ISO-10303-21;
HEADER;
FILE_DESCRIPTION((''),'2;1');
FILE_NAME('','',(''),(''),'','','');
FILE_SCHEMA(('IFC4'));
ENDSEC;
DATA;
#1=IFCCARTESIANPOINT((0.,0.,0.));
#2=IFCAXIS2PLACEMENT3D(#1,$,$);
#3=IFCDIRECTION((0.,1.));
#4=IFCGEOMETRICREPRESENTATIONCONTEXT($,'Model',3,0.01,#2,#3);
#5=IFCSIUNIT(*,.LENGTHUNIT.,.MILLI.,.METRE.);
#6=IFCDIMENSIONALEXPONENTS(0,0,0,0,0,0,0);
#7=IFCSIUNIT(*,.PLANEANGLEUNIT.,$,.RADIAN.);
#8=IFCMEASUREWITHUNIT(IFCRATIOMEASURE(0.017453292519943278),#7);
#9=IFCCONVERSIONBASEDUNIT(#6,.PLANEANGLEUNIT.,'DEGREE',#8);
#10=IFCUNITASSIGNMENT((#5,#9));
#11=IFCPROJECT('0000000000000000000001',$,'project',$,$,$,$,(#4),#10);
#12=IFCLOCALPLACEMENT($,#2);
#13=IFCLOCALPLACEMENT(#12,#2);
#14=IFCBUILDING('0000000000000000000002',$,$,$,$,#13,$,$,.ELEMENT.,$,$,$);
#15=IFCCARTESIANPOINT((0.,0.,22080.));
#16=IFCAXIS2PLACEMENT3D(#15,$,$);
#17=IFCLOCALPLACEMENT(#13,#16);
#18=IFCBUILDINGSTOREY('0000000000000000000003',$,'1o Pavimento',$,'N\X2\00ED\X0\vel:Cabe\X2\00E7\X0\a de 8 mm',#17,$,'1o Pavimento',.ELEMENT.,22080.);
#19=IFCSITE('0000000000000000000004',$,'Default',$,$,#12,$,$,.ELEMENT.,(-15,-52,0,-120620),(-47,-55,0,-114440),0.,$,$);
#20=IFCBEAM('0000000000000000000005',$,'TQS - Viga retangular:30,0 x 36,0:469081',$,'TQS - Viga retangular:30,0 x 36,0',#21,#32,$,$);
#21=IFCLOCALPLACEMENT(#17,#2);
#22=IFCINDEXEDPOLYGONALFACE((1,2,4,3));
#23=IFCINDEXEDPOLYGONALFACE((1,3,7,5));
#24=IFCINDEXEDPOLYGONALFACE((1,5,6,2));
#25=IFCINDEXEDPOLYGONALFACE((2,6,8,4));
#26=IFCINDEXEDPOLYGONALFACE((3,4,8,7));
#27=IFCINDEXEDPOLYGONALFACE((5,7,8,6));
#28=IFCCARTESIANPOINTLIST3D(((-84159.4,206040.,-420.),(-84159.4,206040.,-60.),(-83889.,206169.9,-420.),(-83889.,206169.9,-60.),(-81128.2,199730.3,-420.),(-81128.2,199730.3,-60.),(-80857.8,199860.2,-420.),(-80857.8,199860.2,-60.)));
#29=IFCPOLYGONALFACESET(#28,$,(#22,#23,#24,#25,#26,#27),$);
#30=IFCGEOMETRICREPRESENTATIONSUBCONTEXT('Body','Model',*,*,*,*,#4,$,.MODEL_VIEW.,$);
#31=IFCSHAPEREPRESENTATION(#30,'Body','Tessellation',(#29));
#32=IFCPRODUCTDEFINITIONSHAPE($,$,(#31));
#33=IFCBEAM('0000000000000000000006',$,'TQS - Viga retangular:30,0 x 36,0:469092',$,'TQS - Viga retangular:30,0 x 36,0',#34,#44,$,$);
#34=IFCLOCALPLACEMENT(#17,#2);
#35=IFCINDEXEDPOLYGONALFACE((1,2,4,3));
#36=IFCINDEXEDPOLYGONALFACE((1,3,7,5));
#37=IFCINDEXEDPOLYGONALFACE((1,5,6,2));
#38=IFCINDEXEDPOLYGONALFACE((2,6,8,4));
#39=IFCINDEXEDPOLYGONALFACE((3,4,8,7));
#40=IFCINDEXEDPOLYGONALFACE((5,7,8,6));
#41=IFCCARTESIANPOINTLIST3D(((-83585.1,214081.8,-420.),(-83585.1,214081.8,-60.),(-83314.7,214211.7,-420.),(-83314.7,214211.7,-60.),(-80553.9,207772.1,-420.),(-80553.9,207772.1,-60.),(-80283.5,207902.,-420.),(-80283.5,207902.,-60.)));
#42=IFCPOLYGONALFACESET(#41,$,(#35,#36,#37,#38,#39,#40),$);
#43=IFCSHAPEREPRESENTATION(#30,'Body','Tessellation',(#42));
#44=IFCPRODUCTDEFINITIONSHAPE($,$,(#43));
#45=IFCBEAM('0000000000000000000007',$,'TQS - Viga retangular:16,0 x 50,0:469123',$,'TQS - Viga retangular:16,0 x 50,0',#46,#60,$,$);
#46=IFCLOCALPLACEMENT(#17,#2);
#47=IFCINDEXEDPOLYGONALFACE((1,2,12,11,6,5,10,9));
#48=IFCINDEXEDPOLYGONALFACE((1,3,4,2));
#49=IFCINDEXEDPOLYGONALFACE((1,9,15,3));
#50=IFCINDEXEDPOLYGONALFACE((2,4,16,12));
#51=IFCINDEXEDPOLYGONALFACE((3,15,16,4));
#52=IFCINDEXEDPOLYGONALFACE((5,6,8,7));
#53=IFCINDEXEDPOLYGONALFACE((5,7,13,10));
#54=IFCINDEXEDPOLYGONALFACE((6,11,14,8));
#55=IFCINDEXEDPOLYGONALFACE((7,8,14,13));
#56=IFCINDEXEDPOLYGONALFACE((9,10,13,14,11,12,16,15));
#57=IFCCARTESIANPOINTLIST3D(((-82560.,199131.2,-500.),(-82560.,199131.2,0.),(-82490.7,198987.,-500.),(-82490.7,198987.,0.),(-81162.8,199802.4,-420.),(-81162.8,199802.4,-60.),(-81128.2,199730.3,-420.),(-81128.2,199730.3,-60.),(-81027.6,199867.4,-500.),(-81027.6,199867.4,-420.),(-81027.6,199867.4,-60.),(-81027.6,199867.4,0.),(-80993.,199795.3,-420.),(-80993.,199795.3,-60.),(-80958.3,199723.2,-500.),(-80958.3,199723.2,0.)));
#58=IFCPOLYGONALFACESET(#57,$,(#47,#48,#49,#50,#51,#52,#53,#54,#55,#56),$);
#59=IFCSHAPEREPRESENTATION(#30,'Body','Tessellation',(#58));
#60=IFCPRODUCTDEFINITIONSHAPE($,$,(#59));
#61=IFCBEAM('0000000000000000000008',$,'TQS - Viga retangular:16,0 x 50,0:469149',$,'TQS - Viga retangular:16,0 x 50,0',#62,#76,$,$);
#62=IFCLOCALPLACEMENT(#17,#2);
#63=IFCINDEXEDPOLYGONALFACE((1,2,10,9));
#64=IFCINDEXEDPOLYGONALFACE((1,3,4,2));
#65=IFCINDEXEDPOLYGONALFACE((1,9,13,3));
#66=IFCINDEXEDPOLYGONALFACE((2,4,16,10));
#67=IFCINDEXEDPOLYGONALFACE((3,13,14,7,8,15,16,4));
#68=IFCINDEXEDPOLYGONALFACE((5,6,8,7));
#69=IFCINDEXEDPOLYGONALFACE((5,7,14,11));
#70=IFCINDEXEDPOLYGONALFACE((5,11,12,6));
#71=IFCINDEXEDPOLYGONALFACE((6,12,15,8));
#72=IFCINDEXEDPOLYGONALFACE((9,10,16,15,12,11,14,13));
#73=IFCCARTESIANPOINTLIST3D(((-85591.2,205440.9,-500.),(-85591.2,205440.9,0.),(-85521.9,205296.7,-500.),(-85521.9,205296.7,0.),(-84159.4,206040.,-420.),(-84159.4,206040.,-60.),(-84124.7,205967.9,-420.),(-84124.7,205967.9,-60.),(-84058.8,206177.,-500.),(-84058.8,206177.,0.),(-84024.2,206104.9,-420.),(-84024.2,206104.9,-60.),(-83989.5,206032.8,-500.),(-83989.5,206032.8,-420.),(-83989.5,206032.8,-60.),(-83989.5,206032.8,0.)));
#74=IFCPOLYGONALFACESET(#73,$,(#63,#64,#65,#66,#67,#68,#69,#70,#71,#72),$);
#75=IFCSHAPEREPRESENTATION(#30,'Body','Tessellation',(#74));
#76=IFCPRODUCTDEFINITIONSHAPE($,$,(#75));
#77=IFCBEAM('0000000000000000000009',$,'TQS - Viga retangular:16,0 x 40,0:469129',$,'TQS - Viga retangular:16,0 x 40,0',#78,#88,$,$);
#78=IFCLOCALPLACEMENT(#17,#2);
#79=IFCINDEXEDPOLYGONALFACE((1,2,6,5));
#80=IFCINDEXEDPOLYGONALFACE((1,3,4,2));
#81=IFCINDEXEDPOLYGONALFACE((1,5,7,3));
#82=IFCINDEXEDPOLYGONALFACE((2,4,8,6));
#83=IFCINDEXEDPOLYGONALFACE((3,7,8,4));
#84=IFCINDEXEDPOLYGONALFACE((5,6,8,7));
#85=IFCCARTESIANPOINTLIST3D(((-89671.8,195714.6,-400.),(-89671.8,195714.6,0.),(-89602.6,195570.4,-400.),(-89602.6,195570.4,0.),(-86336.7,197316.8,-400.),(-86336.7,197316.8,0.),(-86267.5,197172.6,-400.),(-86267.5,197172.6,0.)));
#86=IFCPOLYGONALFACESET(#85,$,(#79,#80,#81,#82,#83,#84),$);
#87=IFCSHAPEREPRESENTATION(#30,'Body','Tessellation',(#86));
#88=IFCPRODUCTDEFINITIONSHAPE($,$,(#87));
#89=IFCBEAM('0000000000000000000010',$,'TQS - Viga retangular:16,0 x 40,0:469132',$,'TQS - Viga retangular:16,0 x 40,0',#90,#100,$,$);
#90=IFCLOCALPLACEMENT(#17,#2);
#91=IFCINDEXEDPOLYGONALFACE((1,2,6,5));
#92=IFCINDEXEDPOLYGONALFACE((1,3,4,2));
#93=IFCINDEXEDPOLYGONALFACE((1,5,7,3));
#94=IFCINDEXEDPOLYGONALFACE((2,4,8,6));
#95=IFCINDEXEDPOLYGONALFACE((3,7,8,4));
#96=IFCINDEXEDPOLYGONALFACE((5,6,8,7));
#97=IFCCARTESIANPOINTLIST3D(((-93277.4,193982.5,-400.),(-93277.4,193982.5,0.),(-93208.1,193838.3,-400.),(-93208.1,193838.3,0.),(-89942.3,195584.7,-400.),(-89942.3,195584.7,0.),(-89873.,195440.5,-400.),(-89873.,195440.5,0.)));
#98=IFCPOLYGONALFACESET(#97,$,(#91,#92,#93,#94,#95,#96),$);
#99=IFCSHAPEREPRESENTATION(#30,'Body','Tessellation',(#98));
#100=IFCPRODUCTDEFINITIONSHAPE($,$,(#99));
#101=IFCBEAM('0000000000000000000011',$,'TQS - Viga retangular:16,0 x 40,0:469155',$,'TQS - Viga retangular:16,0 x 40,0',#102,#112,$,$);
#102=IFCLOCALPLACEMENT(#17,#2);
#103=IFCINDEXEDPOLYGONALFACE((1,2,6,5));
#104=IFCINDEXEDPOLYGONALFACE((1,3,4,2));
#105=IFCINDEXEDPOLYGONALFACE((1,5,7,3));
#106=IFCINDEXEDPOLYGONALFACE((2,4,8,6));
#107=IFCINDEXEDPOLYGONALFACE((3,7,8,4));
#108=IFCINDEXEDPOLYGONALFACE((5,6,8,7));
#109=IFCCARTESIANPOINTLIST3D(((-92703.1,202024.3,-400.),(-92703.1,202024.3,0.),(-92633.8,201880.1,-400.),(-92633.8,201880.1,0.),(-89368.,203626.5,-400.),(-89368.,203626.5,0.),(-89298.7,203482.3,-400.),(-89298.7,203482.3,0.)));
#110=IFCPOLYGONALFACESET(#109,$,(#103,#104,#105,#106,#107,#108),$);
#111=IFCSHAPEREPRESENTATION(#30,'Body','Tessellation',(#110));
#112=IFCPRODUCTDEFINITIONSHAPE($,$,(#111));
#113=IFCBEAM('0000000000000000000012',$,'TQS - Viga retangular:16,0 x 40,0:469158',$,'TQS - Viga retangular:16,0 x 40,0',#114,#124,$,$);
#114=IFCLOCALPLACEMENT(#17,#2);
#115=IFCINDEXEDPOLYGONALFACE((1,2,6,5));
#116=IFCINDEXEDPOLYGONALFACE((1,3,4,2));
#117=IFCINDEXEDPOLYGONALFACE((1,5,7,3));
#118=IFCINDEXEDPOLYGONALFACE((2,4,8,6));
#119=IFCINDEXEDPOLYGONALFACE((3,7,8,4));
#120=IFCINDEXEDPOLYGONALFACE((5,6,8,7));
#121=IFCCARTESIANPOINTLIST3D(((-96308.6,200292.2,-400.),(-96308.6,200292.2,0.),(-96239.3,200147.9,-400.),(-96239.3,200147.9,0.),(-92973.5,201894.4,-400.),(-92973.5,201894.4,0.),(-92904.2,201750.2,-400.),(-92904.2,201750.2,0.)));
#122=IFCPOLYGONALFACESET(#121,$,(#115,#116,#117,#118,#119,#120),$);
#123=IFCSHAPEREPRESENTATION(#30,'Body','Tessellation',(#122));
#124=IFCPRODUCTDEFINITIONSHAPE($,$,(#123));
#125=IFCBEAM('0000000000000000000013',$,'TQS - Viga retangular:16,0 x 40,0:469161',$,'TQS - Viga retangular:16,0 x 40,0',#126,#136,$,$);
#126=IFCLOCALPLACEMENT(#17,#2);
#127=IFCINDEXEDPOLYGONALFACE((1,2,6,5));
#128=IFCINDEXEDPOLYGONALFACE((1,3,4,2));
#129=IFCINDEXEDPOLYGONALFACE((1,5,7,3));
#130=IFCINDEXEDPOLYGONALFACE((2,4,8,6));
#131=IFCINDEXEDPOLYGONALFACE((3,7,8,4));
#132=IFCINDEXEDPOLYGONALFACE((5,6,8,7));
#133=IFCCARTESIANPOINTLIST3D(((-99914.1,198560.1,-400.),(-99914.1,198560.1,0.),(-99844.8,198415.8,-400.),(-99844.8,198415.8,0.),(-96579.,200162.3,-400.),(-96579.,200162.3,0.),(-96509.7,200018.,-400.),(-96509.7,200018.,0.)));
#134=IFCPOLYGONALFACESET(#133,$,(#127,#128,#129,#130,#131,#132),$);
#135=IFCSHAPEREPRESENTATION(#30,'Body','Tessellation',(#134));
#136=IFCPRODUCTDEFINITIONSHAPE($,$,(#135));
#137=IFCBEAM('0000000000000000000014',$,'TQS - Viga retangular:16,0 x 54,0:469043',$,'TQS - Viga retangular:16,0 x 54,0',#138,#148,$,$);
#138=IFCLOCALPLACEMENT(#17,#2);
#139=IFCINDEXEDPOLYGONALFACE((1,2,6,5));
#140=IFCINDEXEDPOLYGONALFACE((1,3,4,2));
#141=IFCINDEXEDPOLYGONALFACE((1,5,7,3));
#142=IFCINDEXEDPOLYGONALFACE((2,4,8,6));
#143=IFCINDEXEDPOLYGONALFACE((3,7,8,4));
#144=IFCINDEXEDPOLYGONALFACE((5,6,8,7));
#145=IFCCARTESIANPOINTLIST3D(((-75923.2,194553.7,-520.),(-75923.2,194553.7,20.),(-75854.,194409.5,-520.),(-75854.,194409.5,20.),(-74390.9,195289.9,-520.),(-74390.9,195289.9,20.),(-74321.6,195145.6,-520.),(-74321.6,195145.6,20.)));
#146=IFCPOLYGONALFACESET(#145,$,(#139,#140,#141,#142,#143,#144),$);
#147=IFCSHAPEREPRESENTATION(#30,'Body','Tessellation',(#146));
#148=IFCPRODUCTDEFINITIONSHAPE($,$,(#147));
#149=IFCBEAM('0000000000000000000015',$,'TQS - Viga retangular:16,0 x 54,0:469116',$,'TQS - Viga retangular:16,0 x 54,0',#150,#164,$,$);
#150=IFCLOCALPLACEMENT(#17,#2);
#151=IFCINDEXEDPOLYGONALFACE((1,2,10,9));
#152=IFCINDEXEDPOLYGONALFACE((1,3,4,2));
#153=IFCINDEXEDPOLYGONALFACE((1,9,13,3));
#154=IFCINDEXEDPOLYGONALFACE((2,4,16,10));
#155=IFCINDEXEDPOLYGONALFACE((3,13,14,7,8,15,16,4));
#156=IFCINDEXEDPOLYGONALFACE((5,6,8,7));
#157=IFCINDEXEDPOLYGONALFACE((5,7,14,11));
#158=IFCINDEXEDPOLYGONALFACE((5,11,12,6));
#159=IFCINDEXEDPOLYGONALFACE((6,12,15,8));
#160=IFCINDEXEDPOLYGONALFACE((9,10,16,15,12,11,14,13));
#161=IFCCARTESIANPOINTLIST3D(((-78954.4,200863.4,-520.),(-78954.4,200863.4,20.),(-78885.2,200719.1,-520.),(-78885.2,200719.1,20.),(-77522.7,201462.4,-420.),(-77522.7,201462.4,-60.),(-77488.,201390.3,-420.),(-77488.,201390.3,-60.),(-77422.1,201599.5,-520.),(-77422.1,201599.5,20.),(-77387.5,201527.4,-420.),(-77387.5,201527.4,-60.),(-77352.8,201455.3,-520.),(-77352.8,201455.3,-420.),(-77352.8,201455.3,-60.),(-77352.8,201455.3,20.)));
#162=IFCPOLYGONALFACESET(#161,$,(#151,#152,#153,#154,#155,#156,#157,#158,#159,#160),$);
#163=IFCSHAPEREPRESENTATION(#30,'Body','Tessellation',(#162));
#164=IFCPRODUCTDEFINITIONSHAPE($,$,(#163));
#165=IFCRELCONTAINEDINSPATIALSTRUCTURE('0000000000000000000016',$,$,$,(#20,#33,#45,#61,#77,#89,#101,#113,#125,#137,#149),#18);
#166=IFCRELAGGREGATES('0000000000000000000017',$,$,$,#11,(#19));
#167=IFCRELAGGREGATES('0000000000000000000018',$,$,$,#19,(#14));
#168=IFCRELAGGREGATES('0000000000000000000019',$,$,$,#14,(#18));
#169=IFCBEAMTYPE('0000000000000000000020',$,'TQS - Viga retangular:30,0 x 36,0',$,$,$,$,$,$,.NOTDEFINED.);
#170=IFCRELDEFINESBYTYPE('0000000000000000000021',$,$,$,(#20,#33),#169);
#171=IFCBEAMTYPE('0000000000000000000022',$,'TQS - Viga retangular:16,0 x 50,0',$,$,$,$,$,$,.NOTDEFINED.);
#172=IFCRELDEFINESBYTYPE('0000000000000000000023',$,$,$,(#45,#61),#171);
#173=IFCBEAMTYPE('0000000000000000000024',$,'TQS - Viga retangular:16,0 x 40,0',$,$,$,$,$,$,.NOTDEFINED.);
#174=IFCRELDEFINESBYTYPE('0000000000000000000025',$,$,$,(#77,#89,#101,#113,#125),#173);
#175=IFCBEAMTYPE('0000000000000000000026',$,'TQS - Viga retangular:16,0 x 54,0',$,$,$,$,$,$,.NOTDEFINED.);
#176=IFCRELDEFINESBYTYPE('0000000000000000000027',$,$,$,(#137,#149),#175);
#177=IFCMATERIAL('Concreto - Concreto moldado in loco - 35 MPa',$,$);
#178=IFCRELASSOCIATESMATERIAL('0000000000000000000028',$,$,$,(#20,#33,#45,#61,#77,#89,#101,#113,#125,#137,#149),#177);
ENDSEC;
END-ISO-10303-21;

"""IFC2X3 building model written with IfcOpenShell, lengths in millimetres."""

from ifc_helpers import new_model, entity, si_unit, converted_unit, direction, frame, frame_2d, origin, origin_2d_with_axis, place, context, subcontext, project, spatial, polyline, rectangle, extrude, boolean, clip, bounded_halfspace, material, type_object, element, save


model = new_model("IFC2X3")

# Units and contexts
model_context = context("Model", 3, precision=0.01, world=origin(), true_north=direction((0.0, 1.0)))
body_context = subcontext(model_context, "Body", "Model", "MODEL_VIEW")
ifc_project = project(units=[si_unit("LENGTHUNIT", "METRE", prefix="MILLI"), converted_unit("PLANEANGLEUNIT", "DEGREE", entity("IfcRatioMeasure", 0.017453292519943278), si_unit("PLANEANGLEUNIT", "RADIAN"), dimensions=[0, 0, 0, 0, 0, 0, 0])], contexts=[model_context])

# Site, building, storey
site_placement = place(None, origin())
site = spatial("IfcSite", under=ifc_project, at=site_placement, Name="Default", CompositionType="ELEMENT", RefLatitude=(-15, -52, 0, -120620), RefLongitude=(-47, -55, 0, -114440), RefElevation=0.0)
building_placement = place(site_placement, origin())
building = spatial("IfcBuilding", under=site, at=building_placement, CompositionType="ELEMENT")
storey_placement = place(building_placement, frame((0.0, 0.0, 22080.0)))
storey = spatial("IfcBuildingStorey", under=building, at=storey_placement, Name="1o Pavimento", ObjectType="Nível:Cabeça de 8 mm", LongName="1o Pavimento", CompositionType="ELEMENT", Elevation=22080.0)

# Beams
ifc_material_1 = material(Name="Concreto - Concreto moldado in loco - 35 MPa")
beam_type_1 = type_object("IfcBeamType", Name="TQS - Viga retangular:30,0 x 36,0", PredefinedType="NOTDEFINED")
beam_1_placement = place(storey_placement, frame((-80993.0, 199795.3, -60.0), z_axis=(0.0, 0.0, 1.0), x_axis=(-0.43303, 0.90138, 0.0)))
element("IfcBeam", 1, at=beam_1_placement, inside=storey, type_object=beam_type_1, material=ifc_material_1, Name="TQS - Viga retangular:30,0 x 36,0:469081", ObjectType="TQS - Viga retangular:30,0 x 36,0", context=body_context, shape_type="SweptSolid", body=[
    extrude(rectangle(XDim=360.0, YDim=300.0, at=frame_2d((0.0, 0.0), x_axis=(1.0, 0.0))), frame((0.0, 0.0, -180.0), z_axis=(1.0, 0.0, 0.0), x_axis=(0.0, 0.0, -1.0)), (0.0, 0.0, 1.0), 7000.0),
])
beam_2_placement = place(storey_placement, frame((-80418.7, 207837.1, -60.0), z_axis=(0.0, 0.0, 1.0), x_axis=(-0.43303, 0.90138, 0.0)))
element("IfcBeam", 2, at=beam_2_placement, inside=storey, type_object=beam_type_1, material=ifc_material_1, Name="TQS - Viga retangular:30,0 x 36,0:469092", ObjectType="TQS - Viga retangular:30,0 x 36,0", context=body_context, shape_type="SweptSolid", body=[
    extrude(rectangle(XDim=360.0, YDim=300.0, at=frame_2d((0.0, 0.0), x_axis=(1.0, 0.0))), frame((0.0, 0.0, -180.0), z_axis=(1.0, 0.0, 0.0), x_axis=(0.0, 0.0, -1.0)), (0.0, 0.0, 1.0), 7000.0),
])
beam_type_2 = type_object("IfcBeamType", Name="TQS - Viga retangular:16,0 x 50,0", PredefinedType="NOTDEFINED")
beam_3_placement = place(storey_placement, frame((-80993.0, 199795.3, 0.0), z_axis=(0.0, 0.0, 1.0), x_axis=(-0.90138, -0.43303, 0.0)))
element("IfcBeam", 3, at=beam_3_placement, inside=storey, type_object=beam_type_2, material=ifc_material_1, Name="TQS - Viga retangular:16,0 x 50,0:469123", ObjectType="TQS - Viga retangular:16,0 x 50,0", context=body_context, shape_type="SweptSolid", body=[
    boolean("DIFFERENCE", clip(extrude(rectangle(XDim=500.0, YDim=160.0, at=frame_2d((0.0, 0.0), x_axis=(0.0, 1.0))), frame((0.0, 0.0, -250.0), z_axis=(1.0, 0.0, 0.0), x_axis=(0.0, 1.0, 0.0)), (0.0, 0.0, 1.0), 1700.0), bounded_halfspace(frame((150.0, -7000.0, -420.0), z_axis=(-1.0, 0.0, 0.0), x_axis=(0.0, 1.0, 0.0)), False, frame((0.0, 0.0, -250.0), z_axis=(1.0, 0.0, 0.0), x_axis=(0.0, 1.0, 0.0)), polyline([(0.0, 190.0), (0.0, -170.0), (-80.0, -170.0), (-80.0, 90.0), (-80.0, 190.0), (0.0, 190.0)]))), extrude(rectangle(XDim=360.0, YDim=80.0, at=frame_2d((0.0, 0.0), x_axis=(0.0, 1.0))), frame((150.0, -40.0, -240.0), z_axis=(1.0, 0.0, 0.0), x_axis=(0.0, 1.0, 0.0)), (0.0, 0.0, -1.0), 150.0)),
])
beam_4_placement = place(storey_placement, frame((-84024.2, 206104.9, 0.0), z_axis=(0.0, 0.0, 1.0), x_axis=(-0.90138, -0.43303, 0.0)))
element("IfcBeam", 4, at=beam_4_placement, inside=storey, type_object=beam_type_2, material=ifc_material_1, Name="TQS - Viga retangular:16,0 x 50,0:469149", ObjectType="TQS - Viga retangular:16,0 x 50,0", context=body_context, shape_type="SweptSolid", body=[
    boolean("DIFFERENCE", clip(extrude(rectangle(XDim=500.0, YDim=160.0, at=origin_2d_with_axis()), frame((0.0, 0.0, -250.0), z_axis=(1.0, 0.0, 0.0), x_axis=(0.0, 0.0, -1.0)), (0.0, 0.0, 1.0), 1700.0), bounded_halfspace(frame((150.0, 0.0, -420.0), z_axis=(-1.0, 0.0, 0.0), x_axis=(0.0, 1.0, 0.0)), False, frame((0.0, 0.0, -250.0), z_axis=(1.0, 0.0, 0.0), x_axis=(0.0, 0.0, -1.0)), polyline([(170.0, 0.0), (-190.0, 0.0), (-190.0, 80.0), (-90.0, 80.0), (170.0, 80.0), (170.0, 0.0)]))), extrude(rectangle(XDim=360.0, YDim=80.0, at=frame_2d((0.0, 0.0), x_axis=(0.0, 1.0))), frame((0.0, 40.0, -240.0), z_axis=(-1.0, 0.0, 0.0), x_axis=(0.0, -1.0, 0.0)), (0.0, 0.0, -1.0), 150.0)),
])
beam_type_3 = type_object("IfcBeamType", Name="TQS - Viga retangular:16,0 x 40,0", PredefinedType="NOTDEFINED")
beam_5_placement = place(storey_placement, frame((-86230.0, 197279.4, 0.0), z_axis=(0.0, 0.0, 1.0), x_axis=(-0.90138, -0.43303, 0.0)))
element("IfcBeam", 5, at=beam_5_placement, inside=storey, type_object=beam_type_3, material=ifc_material_1, Name="TQS - Viga retangular:16,0 x 40,0:469129", ObjectType="TQS - Viga retangular:16,0 x 40,0", context=body_context, shape_type="SweptSolid", body=[
    extrude(rectangle(XDim=400.0, YDim=160.0, at=frame_2d((0.0, 0.0), x_axis=(1.0, 0.0))), frame((80.0, 0.0, -200.0), z_axis=(1.0, 0.0, 0.0), x_axis=(0.0, 0.0, -1.0)), (0.0, 0.0, 1.0), 3700.0),
])
beam_6_placement = place(storey_placement, frame((-89835.5, 195547.3, 0.0), z_axis=(0.0, 0.0, 1.0), x_axis=(-0.90138, -0.43303, 0.0)))
element("IfcBeam", 6, at=beam_6_placement, inside=storey, type_object=beam_type_3, material=ifc_material_1, Name="TQS - Viga retangular:16,0 x 40,0:469132", ObjectType="TQS - Viga retangular:16,0 x 40,0", context=body_context, shape_type="SweptSolid", body=[
    extrude(rectangle(XDim=400.0, YDim=160.0, at=frame_2d((0.0, 0.0), x_axis=(1.0, 0.0))), frame((80.0, 0.0, -200.0), z_axis=(1.0, 0.0, 0.0), x_axis=(0.0, 0.0, -1.0)), (0.0, 0.0, 1.0), 3700.0),
])
beam_7_placement = place(storey_placement, frame((-89261.2, 203589.0, 0.0), z_axis=(0.0, 0.0, 1.0), x_axis=(-0.90138, -0.43303, 0.0)))
element("IfcBeam", 7, at=beam_7_placement, inside=storey, type_object=beam_type_3, material=ifc_material_1, Name="TQS - Viga retangular:16,0 x 40,0:469155", ObjectType="TQS - Viga retangular:16,0 x 40,0", context=body_context, shape_type="SweptSolid", body=[
    extrude(rectangle(XDim=400.0, YDim=160.0, at=frame_2d((0.0, 0.0), x_axis=(1.0, 0.0))), frame((80.0, 0.0, -200.0), z_axis=(1.0, 0.0, 0.0), x_axis=(0.0, 0.0, -1.0)), (0.0, 0.0, 1.0), 3700.0),
])
beam_8_placement = place(storey_placement, frame((-92866.7, 201856.9, 0.0), z_axis=(0.0, 0.0, 1.0), x_axis=(-0.90138, -0.43303, 0.0)))
element("IfcBeam", 8, at=beam_8_placement, inside=storey, type_object=beam_type_3, material=ifc_material_1, Name="TQS - Viga retangular:16,0 x 40,0:469158", ObjectType="TQS - Viga retangular:16,0 x 40,0", context=body_context, shape_type="SweptSolid", body=[
    extrude(rectangle(XDim=400.0, YDim=160.0, at=frame_2d((0.0, 0.0), x_axis=(1.0, 0.0))), frame((80.0, 0.0, -200.0), z_axis=(1.0, 0.0, 0.0), x_axis=(0.0, 0.0, -1.0)), (0.0, 0.0, 1.0), 3700.0),
])
beam_9_placement = place(storey_placement, frame((-96472.2, 200124.8, 0.0), z_axis=(0.0, 0.0, 1.0), x_axis=(-0.90138, -0.43303, 0.0)))
element("IfcBeam", 9, at=beam_9_placement, inside=storey, type_object=beam_type_3, material=ifc_material_1, Name="TQS - Viga retangular:16,0 x 40,0:469161", ObjectType="TQS - Viga retangular:16,0 x 40,0", context=body_context, shape_type="SweptSolid", body=[
    extrude(rectangle(XDim=400.0, YDim=160.0, at=frame_2d((0.0, 0.0), x_axis=(1.0, 0.0))), frame((80.0, 0.0, -200.0), z_axis=(1.0, 0.0, 0.0), x_axis=(0.0, 0.0, -1.0)), (0.0, 0.0, 1.0), 3700.0),
])
beam_type_4 = type_object("IfcBeamType", Name="TQS - Viga retangular:16,0 x 54,0", PredefinedType="NOTDEFINED")
beam_10_placement = place(storey_placement, frame((-74356.2, 195217.7, 20.0), z_axis=(0.0, 0.0, 1.0), x_axis=(-0.90138, -0.43303, 0.0)))
element("IfcBeam", 10, at=beam_10_placement, inside=storey, type_object=beam_type_4, material=ifc_material_1, Name="TQS - Viga retangular:16,0 x 54,0:469043", ObjectType="TQS - Viga retangular:16,0 x 54,0", context=body_context, shape_type="SweptSolid", body=[
    extrude(rectangle(XDim=540.0, YDim=160.0, at=frame_2d((0.0, 0.0), x_axis=(1.0, 0.0))), frame((0.0, 0.0, -270.0), z_axis=(1.0, 0.0, 0.0), x_axis=(0.0, 0.0, -1.0)), (0.0, 0.0, 1.0), 1700.0),
])
beam_11_placement = place(storey_placement, frame((-77387.5, 201527.4, 20.0), z_axis=(0.0, 0.0, 1.0), x_axis=(-0.90138, -0.43303, 0.0)))
element("IfcBeam", 11, at=beam_11_placement, inside=storey, type_object=beam_type_4, material=ifc_material_1, Name="TQS - Viga retangular:16,0 x 54,0:469116", ObjectType="TQS - Viga retangular:16,0 x 54,0", context=body_context, shape_type="SweptSolid", body=[
    boolean("DIFFERENCE", clip(extrude(rectangle(XDim=540.0, YDim=160.0, at=origin_2d_with_axis()), frame((0.0, 0.0, -270.0), z_axis=(1.0, 0.0, 0.0), x_axis=(0.0, 0.0, -1.0)), (0.0, 0.0, 1.0), 1700.0), bounded_halfspace(frame((150.0, 0.0, -440.0), z_axis=(-1.0, 0.0, 0.0), x_axis=(0.0, 1.0, 0.0)), False, frame((0.0, 0.0, -270.0), z_axis=(1.0, 0.0, 0.0), x_axis=(0.0, 0.0, -1.0)), polyline([(170.0, 0.0), (-190.0, 0.0), (-190.0, 80.0), (-90.0, 80.0), (170.0, 80.0), (170.0, 0.0)]))), extrude(rectangle(XDim=360.0, YDim=80.0, at=frame_2d((0.0, 0.0), x_axis=(0.0, 1.0))), frame((0.0, 40.0, -260.0), z_axis=(-1.0, 0.0, 0.0), x_axis=(0.0, -1.0, 0.0)), (0.0, 0.0, -1.0), 150.0)),
])

save(model, "model.ifc")
